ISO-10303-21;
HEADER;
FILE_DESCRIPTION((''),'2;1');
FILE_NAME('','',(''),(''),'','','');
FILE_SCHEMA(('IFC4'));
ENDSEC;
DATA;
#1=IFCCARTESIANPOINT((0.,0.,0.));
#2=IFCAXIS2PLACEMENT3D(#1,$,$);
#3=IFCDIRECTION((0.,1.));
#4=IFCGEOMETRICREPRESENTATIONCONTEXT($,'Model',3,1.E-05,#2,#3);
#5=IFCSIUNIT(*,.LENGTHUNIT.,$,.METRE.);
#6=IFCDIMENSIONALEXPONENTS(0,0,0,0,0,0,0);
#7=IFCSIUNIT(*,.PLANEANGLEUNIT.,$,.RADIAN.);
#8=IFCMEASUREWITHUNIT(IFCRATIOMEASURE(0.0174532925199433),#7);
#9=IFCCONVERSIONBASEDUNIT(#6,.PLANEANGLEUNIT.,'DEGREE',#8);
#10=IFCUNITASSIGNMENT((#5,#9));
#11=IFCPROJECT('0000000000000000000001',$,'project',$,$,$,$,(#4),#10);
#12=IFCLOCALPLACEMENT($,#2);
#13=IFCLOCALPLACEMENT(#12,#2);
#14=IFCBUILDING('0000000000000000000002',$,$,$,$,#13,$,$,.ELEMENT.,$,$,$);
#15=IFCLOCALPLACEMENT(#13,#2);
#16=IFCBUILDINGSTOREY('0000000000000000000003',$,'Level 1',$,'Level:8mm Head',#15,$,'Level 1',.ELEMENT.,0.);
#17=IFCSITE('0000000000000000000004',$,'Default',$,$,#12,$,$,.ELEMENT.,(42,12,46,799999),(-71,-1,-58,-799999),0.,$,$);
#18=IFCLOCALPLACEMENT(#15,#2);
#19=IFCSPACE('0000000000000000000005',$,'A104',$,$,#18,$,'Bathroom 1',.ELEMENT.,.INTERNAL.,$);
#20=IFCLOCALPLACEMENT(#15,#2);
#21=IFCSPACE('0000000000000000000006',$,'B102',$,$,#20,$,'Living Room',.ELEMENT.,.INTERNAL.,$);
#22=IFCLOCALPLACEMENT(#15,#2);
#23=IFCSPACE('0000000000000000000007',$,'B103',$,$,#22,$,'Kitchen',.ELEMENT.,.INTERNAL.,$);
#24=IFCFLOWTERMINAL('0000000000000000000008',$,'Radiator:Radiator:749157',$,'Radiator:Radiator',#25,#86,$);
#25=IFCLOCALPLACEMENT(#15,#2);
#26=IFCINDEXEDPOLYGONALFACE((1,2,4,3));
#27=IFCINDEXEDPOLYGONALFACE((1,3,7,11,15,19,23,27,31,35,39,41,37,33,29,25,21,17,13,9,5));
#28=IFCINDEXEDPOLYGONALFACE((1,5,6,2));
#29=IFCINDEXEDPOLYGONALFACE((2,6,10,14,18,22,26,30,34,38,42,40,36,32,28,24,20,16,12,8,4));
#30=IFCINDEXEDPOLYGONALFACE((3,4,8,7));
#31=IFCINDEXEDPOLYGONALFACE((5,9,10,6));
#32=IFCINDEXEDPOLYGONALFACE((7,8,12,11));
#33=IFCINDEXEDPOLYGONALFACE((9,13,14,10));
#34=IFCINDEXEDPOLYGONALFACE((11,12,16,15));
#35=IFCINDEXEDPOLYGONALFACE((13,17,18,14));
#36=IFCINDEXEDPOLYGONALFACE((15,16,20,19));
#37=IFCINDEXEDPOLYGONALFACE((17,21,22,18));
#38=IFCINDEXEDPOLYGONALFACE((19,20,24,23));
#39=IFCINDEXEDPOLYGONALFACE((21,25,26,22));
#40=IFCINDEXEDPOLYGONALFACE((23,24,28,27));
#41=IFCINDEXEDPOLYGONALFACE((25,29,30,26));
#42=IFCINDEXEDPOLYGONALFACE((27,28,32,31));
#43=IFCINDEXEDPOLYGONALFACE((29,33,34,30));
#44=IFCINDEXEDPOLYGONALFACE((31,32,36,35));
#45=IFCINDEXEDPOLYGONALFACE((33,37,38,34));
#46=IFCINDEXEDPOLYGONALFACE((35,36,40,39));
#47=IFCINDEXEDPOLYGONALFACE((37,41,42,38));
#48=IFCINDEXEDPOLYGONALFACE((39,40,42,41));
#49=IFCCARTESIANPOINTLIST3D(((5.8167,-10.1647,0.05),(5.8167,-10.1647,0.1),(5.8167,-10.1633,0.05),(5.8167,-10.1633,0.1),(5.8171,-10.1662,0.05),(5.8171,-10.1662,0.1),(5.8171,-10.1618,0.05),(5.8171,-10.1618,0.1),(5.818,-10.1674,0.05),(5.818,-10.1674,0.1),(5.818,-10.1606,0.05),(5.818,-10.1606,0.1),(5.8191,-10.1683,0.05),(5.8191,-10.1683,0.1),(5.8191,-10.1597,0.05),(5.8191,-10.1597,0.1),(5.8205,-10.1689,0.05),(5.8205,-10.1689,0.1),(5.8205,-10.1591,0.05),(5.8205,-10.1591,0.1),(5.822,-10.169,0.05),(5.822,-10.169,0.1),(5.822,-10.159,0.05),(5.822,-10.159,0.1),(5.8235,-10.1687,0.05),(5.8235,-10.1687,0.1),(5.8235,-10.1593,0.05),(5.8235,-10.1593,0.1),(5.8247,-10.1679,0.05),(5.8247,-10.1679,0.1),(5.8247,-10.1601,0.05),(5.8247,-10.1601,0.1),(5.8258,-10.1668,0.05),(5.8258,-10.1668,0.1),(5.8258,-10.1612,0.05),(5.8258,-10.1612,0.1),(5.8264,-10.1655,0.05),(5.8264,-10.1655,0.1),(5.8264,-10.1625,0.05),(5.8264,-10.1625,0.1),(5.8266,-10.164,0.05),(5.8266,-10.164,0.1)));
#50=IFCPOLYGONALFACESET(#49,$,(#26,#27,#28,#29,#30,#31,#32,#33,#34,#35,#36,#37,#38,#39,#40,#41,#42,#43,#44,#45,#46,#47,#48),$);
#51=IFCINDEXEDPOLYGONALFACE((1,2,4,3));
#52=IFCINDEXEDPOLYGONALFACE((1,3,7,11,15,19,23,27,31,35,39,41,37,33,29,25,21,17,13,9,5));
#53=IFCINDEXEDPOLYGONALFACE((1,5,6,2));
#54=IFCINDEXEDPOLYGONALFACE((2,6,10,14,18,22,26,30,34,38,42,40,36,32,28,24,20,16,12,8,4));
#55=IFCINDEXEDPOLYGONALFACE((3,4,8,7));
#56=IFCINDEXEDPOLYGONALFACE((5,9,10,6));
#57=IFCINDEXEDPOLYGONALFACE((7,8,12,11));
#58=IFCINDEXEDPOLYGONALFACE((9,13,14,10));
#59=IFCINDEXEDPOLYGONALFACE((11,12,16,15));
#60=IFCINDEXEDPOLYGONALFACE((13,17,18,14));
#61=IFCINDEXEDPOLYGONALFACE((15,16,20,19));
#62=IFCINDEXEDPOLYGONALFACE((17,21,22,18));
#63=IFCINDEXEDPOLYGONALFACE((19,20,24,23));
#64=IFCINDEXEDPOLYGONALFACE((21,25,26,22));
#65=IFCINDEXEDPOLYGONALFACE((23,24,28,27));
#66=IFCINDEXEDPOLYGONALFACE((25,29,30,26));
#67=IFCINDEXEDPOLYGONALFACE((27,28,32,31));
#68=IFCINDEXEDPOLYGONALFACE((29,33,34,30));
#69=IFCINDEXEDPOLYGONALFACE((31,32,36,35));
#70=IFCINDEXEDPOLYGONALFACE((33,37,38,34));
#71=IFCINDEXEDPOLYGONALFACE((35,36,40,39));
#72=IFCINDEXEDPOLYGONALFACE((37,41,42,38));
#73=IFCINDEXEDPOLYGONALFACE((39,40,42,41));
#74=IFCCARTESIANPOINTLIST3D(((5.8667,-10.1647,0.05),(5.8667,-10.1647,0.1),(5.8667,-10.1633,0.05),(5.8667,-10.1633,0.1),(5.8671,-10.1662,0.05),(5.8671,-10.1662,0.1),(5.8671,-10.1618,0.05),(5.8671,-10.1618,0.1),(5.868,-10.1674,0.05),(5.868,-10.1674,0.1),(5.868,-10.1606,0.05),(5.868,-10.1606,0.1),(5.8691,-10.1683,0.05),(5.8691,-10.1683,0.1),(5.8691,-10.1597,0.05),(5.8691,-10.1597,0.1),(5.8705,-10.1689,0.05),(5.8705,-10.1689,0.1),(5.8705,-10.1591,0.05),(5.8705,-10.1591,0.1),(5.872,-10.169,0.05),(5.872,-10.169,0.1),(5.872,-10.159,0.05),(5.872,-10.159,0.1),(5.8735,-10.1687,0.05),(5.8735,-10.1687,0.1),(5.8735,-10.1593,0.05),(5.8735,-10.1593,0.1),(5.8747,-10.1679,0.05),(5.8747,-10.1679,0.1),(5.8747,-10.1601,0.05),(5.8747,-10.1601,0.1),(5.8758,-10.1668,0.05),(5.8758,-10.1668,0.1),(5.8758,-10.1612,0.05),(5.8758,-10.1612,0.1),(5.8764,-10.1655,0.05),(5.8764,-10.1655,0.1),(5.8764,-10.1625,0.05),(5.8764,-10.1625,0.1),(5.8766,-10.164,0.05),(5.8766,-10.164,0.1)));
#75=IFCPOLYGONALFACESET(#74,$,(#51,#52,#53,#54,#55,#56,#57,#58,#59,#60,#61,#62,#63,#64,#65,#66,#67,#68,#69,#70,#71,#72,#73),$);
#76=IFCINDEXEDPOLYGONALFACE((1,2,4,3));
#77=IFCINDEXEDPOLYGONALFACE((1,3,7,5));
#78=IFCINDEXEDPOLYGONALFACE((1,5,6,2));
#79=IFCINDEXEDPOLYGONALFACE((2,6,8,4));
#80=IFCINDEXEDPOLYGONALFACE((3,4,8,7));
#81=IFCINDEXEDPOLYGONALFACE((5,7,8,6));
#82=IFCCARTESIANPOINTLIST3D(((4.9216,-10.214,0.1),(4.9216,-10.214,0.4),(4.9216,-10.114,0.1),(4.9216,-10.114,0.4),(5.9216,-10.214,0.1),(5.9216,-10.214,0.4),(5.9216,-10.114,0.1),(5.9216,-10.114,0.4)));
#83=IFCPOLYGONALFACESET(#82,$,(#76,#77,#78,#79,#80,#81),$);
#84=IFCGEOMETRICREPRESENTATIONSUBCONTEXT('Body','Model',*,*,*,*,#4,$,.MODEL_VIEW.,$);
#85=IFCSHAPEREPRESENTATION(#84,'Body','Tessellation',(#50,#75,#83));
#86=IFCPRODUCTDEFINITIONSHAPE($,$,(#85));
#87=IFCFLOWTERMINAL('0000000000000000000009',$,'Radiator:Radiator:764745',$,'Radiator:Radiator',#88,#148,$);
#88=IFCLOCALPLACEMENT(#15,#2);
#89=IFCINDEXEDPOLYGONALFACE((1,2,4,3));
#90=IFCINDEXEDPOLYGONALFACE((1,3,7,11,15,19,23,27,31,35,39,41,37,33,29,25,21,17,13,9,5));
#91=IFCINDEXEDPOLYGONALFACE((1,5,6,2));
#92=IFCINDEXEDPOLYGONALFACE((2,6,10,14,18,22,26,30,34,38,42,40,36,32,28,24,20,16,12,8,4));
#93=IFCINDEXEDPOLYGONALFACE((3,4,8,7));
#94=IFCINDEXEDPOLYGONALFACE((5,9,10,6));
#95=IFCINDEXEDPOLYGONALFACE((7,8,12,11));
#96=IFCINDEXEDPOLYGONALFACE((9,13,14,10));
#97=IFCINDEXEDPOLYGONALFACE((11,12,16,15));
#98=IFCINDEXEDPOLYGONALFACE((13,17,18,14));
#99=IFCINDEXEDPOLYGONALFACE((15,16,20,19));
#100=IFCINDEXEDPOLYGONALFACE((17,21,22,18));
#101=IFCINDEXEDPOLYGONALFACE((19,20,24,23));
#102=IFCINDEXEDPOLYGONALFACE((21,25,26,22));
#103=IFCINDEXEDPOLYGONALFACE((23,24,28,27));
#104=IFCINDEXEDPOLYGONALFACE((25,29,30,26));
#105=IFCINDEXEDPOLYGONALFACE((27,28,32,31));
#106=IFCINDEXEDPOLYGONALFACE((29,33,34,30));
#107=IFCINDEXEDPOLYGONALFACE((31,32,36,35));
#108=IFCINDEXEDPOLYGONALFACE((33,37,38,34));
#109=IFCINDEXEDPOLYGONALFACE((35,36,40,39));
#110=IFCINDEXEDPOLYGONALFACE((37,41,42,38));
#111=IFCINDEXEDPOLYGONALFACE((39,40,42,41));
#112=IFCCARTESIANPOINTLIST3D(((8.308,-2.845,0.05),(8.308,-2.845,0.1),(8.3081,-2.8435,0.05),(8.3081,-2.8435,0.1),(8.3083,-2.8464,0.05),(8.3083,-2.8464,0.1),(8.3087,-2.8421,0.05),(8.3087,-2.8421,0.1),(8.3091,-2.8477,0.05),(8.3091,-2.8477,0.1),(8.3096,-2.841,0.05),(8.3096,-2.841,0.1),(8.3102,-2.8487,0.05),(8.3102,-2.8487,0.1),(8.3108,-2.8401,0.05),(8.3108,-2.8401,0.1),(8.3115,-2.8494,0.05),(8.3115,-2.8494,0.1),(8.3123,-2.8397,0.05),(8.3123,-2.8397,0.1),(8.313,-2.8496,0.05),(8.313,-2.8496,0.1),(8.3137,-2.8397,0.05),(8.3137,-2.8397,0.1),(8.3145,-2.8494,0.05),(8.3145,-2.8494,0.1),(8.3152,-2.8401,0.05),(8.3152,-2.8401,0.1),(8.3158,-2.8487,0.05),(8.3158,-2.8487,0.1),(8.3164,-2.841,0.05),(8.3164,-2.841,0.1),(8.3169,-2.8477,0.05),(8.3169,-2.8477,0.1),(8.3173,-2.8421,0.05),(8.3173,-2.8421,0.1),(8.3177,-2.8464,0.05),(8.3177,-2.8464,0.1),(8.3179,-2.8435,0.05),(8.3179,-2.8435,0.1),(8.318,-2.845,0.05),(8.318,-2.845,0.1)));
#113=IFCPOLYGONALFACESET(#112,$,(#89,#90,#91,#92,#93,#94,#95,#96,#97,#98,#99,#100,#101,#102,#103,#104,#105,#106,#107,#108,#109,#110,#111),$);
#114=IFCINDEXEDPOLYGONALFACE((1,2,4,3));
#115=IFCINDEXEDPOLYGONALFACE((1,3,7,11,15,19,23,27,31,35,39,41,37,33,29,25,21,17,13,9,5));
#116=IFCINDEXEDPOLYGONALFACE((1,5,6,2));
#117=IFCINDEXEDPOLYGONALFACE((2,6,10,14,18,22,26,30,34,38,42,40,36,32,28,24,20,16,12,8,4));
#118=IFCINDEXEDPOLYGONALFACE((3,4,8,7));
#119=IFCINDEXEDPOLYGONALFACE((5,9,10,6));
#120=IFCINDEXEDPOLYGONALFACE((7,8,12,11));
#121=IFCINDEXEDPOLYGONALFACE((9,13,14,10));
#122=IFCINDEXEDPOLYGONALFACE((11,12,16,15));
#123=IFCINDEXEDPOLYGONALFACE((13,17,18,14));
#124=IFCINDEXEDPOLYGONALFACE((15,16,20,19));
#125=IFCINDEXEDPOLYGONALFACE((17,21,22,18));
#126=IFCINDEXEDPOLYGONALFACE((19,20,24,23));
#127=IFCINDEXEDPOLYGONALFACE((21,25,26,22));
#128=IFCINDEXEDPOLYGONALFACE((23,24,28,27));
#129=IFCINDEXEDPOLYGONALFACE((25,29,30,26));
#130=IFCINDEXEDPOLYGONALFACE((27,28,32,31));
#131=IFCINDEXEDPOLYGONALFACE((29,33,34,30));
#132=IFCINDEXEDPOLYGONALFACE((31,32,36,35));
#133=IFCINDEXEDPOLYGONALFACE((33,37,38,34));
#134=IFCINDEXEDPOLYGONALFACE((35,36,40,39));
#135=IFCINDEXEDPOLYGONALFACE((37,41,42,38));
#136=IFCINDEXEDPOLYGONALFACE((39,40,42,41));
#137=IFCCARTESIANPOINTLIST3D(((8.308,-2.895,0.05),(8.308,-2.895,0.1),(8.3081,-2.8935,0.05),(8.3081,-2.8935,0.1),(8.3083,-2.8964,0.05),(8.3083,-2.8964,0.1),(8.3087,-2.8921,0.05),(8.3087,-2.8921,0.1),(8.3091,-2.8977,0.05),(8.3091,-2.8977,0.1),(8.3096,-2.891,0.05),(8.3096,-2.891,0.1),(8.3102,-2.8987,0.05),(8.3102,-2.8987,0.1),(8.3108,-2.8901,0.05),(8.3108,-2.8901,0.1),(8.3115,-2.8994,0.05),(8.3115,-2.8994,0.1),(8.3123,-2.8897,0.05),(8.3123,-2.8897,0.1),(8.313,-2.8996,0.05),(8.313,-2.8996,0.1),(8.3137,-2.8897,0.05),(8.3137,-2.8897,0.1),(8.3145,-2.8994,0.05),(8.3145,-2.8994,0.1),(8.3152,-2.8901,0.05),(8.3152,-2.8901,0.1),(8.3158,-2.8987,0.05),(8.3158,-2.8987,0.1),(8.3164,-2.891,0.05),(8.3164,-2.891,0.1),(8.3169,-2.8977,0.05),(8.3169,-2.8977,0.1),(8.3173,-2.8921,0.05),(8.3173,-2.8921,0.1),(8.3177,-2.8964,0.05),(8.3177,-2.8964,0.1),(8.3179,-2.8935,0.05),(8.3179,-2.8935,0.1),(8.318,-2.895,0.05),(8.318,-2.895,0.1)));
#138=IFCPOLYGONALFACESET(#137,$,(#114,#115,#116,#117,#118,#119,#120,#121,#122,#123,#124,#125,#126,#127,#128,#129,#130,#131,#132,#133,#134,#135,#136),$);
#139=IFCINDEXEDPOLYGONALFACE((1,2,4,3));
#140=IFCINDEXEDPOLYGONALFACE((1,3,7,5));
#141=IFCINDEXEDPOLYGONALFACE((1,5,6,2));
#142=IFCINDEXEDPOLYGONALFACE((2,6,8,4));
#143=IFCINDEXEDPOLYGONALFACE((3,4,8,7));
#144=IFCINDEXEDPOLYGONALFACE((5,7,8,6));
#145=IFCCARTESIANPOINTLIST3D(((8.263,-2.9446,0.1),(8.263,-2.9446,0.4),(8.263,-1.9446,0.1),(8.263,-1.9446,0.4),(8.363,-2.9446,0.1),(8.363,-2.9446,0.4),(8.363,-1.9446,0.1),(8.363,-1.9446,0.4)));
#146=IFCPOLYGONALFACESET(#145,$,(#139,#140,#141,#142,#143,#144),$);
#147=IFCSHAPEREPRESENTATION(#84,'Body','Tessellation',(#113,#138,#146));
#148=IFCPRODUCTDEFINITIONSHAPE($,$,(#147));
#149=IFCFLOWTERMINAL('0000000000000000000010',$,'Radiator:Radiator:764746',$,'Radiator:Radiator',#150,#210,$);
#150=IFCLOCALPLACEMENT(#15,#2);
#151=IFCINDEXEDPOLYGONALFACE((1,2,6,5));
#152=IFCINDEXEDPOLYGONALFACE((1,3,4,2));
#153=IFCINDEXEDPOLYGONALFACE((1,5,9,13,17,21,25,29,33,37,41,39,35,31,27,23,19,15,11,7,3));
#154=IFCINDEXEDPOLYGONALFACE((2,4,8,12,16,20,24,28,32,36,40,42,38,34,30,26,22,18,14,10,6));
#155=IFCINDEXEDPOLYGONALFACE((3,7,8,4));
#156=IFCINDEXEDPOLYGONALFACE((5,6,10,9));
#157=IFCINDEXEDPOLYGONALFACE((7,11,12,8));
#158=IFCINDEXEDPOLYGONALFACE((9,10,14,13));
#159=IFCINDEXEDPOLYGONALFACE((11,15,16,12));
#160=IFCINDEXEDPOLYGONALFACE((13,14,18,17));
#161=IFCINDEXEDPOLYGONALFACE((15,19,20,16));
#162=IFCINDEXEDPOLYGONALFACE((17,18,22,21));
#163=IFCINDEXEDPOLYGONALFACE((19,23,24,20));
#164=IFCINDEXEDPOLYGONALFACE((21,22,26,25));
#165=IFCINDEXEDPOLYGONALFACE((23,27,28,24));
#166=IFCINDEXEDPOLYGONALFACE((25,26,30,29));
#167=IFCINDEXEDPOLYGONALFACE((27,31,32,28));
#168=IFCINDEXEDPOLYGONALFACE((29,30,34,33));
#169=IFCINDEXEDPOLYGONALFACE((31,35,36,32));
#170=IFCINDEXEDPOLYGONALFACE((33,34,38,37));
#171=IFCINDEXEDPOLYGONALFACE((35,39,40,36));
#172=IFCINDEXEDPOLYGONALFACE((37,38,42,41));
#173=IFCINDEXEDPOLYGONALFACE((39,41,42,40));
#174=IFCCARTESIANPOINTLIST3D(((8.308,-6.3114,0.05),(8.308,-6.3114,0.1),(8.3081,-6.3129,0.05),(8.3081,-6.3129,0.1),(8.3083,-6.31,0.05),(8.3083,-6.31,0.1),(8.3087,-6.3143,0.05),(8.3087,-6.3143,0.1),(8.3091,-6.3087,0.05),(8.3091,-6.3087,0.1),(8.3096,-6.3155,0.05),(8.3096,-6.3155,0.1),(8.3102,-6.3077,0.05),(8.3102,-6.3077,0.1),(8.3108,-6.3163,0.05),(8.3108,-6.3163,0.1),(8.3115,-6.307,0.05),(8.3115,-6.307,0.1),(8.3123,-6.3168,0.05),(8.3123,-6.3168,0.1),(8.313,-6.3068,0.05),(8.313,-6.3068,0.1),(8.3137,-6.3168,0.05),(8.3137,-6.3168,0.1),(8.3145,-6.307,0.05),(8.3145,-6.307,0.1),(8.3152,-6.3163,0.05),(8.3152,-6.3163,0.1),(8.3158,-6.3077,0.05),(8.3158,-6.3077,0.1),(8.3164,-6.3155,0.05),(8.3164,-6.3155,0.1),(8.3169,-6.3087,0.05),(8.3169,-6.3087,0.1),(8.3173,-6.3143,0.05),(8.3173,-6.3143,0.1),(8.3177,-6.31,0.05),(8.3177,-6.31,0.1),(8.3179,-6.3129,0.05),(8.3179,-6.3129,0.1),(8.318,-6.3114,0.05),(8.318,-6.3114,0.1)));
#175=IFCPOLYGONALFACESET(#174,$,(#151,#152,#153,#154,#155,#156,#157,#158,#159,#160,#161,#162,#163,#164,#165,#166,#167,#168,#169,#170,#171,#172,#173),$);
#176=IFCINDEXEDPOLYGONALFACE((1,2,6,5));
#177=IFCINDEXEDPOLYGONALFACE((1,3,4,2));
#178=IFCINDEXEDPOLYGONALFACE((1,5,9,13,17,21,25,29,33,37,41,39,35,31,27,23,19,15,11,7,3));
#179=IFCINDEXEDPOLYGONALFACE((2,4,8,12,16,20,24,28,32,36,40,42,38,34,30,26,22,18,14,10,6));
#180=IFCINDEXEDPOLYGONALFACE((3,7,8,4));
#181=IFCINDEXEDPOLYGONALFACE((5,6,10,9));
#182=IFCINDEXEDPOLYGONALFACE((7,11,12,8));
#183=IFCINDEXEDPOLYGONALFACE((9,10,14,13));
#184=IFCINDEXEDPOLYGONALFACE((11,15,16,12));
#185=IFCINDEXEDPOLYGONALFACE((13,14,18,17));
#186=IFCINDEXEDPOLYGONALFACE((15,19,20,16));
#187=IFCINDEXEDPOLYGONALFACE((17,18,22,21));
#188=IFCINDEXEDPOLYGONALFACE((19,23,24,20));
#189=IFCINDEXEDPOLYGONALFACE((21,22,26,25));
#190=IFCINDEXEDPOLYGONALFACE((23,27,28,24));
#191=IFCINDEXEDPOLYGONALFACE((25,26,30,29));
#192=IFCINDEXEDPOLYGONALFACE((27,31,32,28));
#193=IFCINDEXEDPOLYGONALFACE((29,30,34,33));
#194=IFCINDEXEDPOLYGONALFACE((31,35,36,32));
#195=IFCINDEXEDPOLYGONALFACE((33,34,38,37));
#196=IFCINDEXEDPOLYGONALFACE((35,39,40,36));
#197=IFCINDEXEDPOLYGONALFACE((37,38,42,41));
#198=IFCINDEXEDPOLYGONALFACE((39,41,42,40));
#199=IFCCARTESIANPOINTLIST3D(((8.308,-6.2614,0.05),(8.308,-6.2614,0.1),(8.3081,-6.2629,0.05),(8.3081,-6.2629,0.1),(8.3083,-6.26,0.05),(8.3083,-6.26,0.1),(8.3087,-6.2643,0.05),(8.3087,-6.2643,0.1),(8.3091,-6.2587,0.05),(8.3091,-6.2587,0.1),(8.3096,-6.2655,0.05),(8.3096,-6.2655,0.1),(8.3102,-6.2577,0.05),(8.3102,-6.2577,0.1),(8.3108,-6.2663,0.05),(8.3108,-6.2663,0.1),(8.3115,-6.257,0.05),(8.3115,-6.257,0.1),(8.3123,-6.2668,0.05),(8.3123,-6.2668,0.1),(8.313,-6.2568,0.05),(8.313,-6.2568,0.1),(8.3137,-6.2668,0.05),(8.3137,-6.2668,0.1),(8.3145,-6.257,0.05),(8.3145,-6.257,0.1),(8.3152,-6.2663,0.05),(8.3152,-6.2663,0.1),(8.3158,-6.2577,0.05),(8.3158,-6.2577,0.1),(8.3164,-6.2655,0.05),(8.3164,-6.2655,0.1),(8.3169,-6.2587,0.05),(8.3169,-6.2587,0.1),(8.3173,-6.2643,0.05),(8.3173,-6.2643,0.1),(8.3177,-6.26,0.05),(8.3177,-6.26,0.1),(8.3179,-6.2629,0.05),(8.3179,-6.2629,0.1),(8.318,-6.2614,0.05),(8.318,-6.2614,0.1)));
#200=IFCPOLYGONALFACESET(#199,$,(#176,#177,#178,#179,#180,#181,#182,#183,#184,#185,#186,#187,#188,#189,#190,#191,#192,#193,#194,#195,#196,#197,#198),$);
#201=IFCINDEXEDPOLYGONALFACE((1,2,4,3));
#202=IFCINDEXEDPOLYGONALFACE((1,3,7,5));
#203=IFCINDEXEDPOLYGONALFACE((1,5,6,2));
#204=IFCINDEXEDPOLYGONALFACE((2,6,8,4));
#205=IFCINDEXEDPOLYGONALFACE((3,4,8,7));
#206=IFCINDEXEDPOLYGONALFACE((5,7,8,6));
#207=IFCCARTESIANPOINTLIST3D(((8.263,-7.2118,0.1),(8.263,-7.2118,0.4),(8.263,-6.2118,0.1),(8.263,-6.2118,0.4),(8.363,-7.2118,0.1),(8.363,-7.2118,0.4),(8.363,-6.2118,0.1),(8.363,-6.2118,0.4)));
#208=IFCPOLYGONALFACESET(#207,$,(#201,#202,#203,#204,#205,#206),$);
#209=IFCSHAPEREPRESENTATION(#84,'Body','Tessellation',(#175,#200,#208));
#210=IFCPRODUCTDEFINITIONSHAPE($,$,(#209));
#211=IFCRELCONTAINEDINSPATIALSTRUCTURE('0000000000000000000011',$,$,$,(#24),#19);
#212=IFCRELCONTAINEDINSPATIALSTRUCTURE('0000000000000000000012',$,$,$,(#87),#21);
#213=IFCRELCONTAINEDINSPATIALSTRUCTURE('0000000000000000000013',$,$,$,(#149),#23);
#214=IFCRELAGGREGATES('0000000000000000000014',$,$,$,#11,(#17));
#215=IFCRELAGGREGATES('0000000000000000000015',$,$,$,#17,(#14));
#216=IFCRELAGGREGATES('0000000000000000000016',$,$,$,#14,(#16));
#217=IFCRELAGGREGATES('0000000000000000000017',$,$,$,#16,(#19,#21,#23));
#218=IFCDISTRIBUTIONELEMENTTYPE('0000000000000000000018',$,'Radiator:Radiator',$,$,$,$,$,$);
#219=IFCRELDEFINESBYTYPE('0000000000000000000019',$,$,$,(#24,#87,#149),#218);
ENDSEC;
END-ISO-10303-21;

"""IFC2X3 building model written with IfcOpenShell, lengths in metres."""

from ifc_helpers import new_model, entity, si_unit, converted_unit, direction, frame, frame_2d, origin, origin_2d_with_axis, place, context, subcontext, project, spatial, rectangle, circle, extrude, source, transform, mapped, type_object, type_shapes, element, save


model = new_model("IFC2X3")

# Units and contexts
model_context = context("Model", 3, precision=1e-05, world=origin(), true_north=direction((0.0, 1.0)))
body_context = subcontext(model_context, "Body", "Model", "MODEL_VIEW")
ifc_project = project(units=[si_unit("LENGTHUNIT", "METRE"), converted_unit("PLANEANGLEUNIT", "DEGREE", entity("IfcRatioMeasure", 0.0174532925199433), si_unit("PLANEANGLEUNIT", "RADIAN"), dimensions=[0, 0, 0, 0, 0, 0, 0])], contexts=[model_context])

# Site, building, storey
site_placement = place(None, origin())
site = spatial("IfcSite", under=ifc_project, at=site_placement, Name="Default", CompositionType="ELEMENT", RefLatitude=(42, 12, 46, 799999), RefLongitude=(-71, -1, -58, -799999), RefElevation=0.0)
building_placement = place(site_placement, origin())
building = spatial("IfcBuilding", under=site, at=building_placement, CompositionType="ELEMENT")
storey_placement = place(building_placement, origin())
storey = spatial("IfcBuildingStorey", under=building, at=storey_placement, Name="Level 1", ObjectType="Level:8mm Head", LongName="Level 1", CompositionType="ELEMENT", Elevation=0.0)

# Shared definitions
distribution_element_type_1 = type_object("IfcDistributionElementType", Name="Radiator:Radiator")
shared_shape_1 = source(origin(), body_context, "Body", "SweptSolid", [
    extrude(circle(Radius=0.005, at=frame_2d((0.0, 0.0), x_axis=(1.0, 0.0))), frame((0.4, 0.0, -0.05)), (0.0, 0.0, 1.0), 0.05),
    extrude(circle(Radius=0.005, at=frame_2d((0.0, 0.0), x_axis=(1.0, 0.0))), frame((0.45, 0.0, -0.05)), (0.0, 0.0, 1.0), 0.05),
    extrude(rectangle(XDim=1.0, YDim=0.1, at=origin_2d_with_axis()), frame((0.0, 0.0, 0.0), z_axis=(0.0, 0.0, 1.0), x_axis=(-1.0, 0.0, 0.0)), (0.0, 0.0, 1.0), 0.3),
])
type_shapes(distribution_element_type_1, [shared_shape_1])

# Shared definitions
space_1_placement = place(storey_placement, origin())
space_1 = spatial("IfcSpace", under=storey, at=space_1_placement, Name="A104", LongName="Bathroom 1", CompositionType="ELEMENT", InteriorOrExteriorSpace="INTERNAL")

# Flow terminal
flow_terminal_1_placement = place(space_1_placement, frame((5.4216, -10.164, 0.1)))
element("IfcFlowTerminal", 1, at=flow_terminal_1_placement, inside=space_1, type_object=distribution_element_type_1, Name="Radiator:Radiator:749157", ObjectType="Radiator:Radiator", context=body_context, shape_type="MappedRepresentation", body=[
    mapped(shared_shape_1, transform((0.0, 0.0, 0.0), scale=1.0)),
])

# Shared definitions
space_2_placement = place(storey_placement, origin())
space_2 = spatial("IfcSpace", under=storey, at=space_2_placement, Name="B102", LongName="Living Room", CompositionType="ELEMENT", InteriorOrExteriorSpace="INTERNAL")

# Flow terminal
flow_terminal_2_placement = place(space_2_placement, frame((8.313, -2.4446, 0.1), z_axis=(0.0, 0.0, 1.0), x_axis=(0.0, -1.0, 0.0)))
element("IfcFlowTerminal", 2, at=flow_terminal_2_placement, inside=space_2, type_object=distribution_element_type_1, Name="Radiator:Radiator:764745", ObjectType="Radiator:Radiator", context=body_context, shape_type="MappedRepresentation", body=[
    mapped(shared_shape_1, transform((0.0, 0.0, 0.0), scale=1.0)),
])

# Shared definitions
space_3_placement = place(storey_placement, origin())
space_3 = spatial("IfcSpace", under=storey, at=space_3_placement, Name="B103", LongName="Kitchen", CompositionType="ELEMENT", InteriorOrExteriorSpace="INTERNAL")

# Flow terminal
flow_terminal_3_placement = place(space_3_placement, frame((8.313, -6.7118, 0.1), z_axis=(0.0, 0.0, 1.0), x_axis=(0.0, 1.0, 0.0)))
element("IfcFlowTerminal", 3, at=flow_terminal_3_placement, inside=space_3, type_object=distribution_element_type_1, Name="Radiator:Radiator:764746", ObjectType="Radiator:Radiator", context=body_context, shape_type="MappedRepresentation", body=[
    mapped(shared_shape_1, transform((0.0, 0.0, 0.0), scale=1.0)),
])

save(model, "model.ifc")
